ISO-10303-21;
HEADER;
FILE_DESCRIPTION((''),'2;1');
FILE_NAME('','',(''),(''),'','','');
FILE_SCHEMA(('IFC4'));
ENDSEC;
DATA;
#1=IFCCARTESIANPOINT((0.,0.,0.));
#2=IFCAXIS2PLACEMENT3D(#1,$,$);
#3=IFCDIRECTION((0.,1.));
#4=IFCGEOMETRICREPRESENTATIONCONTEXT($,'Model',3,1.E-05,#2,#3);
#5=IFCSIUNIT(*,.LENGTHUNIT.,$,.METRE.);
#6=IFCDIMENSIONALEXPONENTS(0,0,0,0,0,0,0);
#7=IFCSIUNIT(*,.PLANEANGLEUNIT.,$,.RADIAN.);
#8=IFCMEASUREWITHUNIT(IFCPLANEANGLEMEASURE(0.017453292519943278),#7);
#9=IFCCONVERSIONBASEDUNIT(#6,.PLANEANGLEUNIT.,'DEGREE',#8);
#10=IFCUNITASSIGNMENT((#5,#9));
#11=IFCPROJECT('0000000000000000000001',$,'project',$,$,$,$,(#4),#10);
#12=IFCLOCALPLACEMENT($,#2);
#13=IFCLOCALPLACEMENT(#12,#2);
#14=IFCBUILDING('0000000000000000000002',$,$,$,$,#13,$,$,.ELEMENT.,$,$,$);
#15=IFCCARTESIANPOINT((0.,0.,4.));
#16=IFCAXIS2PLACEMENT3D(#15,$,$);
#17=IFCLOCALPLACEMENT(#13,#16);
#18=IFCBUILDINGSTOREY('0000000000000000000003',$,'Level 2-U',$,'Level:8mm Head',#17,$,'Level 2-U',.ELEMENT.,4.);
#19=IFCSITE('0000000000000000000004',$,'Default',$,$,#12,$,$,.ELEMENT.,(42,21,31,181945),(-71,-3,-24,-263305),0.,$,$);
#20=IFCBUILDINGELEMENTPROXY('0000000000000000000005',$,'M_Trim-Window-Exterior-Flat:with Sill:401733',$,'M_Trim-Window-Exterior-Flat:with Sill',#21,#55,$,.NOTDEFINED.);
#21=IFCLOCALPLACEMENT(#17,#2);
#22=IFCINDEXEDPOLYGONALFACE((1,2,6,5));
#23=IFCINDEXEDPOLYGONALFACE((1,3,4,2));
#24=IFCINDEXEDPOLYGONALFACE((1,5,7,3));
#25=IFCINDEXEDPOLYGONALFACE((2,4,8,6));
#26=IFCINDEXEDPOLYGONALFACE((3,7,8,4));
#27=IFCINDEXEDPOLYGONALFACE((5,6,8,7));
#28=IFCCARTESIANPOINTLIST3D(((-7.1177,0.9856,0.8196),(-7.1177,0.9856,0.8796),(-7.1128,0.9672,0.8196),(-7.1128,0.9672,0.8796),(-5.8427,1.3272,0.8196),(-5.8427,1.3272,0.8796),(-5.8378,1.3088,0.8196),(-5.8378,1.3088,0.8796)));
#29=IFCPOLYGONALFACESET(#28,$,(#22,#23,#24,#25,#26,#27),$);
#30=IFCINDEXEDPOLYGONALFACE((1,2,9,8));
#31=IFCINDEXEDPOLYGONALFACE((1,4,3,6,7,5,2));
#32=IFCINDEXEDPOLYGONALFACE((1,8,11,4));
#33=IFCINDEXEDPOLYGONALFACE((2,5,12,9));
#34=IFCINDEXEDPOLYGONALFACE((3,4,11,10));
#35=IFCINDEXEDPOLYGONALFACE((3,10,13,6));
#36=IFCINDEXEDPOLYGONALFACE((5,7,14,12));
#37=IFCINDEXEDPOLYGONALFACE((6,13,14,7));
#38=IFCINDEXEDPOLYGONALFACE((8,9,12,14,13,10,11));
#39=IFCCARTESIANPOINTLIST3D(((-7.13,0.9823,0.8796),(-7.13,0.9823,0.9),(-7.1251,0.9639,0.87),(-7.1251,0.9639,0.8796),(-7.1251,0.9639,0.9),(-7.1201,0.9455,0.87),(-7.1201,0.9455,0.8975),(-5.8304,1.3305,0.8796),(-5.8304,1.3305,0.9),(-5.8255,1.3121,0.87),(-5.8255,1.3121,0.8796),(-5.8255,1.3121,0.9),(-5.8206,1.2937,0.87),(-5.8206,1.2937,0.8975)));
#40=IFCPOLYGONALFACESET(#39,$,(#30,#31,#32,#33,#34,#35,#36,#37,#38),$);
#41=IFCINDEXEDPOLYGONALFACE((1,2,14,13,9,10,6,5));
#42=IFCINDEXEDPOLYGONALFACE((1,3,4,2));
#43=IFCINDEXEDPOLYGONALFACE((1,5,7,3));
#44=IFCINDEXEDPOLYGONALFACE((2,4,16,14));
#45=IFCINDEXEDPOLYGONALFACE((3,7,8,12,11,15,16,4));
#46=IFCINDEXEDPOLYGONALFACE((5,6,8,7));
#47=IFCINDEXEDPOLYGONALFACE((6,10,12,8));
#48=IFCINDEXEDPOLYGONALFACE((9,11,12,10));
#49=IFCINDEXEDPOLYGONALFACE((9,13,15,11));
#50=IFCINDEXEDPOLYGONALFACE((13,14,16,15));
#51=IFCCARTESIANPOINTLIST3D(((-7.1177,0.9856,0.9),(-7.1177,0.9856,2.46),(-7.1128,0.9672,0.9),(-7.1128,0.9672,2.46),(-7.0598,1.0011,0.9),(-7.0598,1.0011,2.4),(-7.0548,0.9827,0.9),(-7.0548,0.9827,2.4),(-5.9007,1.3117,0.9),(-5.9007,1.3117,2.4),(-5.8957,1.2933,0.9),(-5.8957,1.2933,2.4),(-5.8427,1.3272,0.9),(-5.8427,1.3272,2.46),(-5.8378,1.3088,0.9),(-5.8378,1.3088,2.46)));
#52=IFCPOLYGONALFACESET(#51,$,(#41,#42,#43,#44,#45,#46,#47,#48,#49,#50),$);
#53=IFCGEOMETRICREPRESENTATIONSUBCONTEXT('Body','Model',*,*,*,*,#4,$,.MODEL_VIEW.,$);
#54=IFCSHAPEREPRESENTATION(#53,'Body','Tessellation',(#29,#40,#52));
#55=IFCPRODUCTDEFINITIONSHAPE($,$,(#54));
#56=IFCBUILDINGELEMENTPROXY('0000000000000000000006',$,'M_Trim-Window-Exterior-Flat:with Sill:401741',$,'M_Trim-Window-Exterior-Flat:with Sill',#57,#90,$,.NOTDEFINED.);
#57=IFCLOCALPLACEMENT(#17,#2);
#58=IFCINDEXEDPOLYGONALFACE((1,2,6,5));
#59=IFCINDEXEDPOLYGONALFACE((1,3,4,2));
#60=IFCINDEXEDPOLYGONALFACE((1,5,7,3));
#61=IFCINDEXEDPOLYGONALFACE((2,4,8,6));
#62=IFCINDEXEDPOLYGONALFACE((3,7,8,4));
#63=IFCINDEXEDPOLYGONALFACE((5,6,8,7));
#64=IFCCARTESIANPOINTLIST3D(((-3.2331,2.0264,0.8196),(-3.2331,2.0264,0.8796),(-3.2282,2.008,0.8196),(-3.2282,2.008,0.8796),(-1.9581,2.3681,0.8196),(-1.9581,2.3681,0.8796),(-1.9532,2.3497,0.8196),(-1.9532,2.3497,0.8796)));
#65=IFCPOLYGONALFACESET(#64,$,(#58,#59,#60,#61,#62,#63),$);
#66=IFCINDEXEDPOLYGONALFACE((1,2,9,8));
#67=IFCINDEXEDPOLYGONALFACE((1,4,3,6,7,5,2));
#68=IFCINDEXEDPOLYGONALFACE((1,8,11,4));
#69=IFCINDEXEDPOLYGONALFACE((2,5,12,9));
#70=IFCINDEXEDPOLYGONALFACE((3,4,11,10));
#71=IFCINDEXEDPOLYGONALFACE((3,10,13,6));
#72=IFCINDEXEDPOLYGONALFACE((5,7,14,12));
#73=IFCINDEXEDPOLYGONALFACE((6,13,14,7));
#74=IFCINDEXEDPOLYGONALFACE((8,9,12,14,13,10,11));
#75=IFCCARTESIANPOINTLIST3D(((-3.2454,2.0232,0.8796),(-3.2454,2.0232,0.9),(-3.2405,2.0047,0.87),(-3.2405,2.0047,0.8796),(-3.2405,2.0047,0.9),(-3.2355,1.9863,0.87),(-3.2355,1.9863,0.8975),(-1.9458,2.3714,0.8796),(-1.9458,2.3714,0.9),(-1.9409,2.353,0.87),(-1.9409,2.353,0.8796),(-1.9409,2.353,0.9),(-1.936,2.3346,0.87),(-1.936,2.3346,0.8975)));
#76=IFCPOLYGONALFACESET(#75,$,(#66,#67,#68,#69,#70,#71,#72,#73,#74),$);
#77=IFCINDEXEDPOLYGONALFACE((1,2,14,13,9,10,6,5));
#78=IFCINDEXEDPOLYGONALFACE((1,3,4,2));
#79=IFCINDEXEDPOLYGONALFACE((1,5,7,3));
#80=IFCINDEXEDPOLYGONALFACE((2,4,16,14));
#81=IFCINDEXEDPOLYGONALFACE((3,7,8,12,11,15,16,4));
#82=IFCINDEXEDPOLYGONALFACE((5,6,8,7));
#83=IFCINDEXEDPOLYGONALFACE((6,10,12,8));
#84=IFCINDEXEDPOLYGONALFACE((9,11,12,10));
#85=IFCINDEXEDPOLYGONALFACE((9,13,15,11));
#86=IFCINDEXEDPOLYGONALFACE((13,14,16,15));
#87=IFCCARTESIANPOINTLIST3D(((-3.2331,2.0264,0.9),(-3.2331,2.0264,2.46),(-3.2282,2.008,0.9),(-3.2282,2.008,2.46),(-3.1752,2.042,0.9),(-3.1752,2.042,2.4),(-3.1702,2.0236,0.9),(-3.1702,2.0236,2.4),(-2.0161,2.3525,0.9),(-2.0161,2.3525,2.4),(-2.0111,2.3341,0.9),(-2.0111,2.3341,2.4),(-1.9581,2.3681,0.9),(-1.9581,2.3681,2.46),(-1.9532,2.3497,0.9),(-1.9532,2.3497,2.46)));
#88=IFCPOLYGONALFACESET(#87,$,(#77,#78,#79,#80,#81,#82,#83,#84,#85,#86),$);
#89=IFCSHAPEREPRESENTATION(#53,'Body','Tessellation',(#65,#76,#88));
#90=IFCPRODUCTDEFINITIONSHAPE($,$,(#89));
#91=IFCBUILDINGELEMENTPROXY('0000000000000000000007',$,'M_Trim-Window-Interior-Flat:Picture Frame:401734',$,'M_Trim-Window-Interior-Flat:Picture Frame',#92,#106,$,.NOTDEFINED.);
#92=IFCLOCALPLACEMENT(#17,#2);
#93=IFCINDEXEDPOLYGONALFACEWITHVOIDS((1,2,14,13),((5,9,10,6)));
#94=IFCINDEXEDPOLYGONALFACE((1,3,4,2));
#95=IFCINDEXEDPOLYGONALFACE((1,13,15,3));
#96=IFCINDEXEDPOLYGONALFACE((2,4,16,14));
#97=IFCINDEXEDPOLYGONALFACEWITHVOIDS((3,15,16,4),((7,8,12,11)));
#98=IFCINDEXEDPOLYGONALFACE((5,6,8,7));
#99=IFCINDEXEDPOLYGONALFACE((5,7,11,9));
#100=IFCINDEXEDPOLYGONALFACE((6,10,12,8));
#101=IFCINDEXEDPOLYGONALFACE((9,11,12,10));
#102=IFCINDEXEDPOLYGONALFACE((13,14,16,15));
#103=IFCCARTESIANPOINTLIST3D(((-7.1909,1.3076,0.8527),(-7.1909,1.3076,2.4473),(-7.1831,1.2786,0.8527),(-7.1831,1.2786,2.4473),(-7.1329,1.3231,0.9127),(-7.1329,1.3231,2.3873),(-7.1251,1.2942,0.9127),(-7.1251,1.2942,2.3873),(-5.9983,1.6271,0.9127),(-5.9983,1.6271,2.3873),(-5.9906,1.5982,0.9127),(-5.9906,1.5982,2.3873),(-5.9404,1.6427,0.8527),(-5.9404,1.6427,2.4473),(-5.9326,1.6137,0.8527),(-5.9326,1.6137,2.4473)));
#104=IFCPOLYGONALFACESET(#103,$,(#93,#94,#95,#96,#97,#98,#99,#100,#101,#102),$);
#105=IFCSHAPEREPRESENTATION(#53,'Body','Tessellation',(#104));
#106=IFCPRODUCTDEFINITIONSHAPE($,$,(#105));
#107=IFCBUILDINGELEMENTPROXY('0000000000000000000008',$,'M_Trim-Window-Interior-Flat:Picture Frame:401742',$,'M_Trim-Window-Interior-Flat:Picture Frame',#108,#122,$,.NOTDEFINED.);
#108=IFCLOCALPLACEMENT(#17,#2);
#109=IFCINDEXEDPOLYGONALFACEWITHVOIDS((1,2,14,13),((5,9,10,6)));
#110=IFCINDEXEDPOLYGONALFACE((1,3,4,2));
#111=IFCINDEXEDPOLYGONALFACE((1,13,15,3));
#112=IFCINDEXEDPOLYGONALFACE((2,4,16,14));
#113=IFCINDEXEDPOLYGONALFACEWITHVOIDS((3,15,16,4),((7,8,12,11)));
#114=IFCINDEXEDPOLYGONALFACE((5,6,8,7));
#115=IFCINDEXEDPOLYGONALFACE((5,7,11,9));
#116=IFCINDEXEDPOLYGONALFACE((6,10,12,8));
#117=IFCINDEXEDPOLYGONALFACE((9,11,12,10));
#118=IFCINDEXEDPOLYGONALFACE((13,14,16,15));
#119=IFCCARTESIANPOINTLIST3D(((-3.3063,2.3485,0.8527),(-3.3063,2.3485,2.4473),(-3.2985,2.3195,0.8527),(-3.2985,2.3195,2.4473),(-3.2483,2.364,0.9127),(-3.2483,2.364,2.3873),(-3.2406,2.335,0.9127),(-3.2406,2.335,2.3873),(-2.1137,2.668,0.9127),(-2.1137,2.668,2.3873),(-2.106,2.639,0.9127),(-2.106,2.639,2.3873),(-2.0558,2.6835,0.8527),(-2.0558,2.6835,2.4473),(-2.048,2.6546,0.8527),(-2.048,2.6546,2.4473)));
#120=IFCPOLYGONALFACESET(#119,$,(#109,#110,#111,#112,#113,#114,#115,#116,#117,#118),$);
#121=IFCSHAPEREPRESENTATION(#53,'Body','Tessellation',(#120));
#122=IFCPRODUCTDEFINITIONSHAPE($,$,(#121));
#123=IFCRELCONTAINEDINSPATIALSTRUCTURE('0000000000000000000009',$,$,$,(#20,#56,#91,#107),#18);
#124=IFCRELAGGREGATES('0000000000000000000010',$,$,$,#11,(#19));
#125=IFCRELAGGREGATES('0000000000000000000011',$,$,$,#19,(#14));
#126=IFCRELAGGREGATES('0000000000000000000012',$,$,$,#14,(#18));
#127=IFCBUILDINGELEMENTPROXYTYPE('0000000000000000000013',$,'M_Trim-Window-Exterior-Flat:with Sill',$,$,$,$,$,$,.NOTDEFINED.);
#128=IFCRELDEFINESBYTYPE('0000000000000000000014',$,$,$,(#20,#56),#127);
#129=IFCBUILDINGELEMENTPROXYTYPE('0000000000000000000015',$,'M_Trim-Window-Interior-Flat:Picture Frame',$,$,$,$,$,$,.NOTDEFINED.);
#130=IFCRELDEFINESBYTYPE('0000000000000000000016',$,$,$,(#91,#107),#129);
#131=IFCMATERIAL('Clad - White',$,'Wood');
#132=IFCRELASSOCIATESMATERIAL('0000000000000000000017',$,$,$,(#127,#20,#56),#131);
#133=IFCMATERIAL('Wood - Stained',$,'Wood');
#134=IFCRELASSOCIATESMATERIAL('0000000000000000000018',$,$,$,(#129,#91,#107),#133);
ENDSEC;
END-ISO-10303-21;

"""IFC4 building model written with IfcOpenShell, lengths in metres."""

from ifc_helpers import new_model, entity, si_unit, converted_unit, direction, frame, origin, place, context, subcontext, project, spatial, indexed_curve, outline, extrude, source, transform, mapped, material, type_object, type_shapes, element, save


model = new_model("IFC4")

# Units and contexts
model_context = context("Model", 3, precision=1e-05, world=origin(), true_north=direction((0.0, 1.0)))
body_context = subcontext(model_context, "Body", "Model", "MODEL_VIEW")
ifc_project = project(units=[si_unit("LENGTHUNIT", "METRE"), converted_unit("PLANEANGLEUNIT", "DEGREE", entity("IfcPlaneAngleMeasure", 0.017453292519943278), si_unit("PLANEANGLEUNIT", "RADIAN"), dimensions=[0, 0, 0, 0, 0, 0, 0])], contexts=[model_context])

# Site, building, storey
site_placement = place(None, origin())
site = spatial("IfcSite", under=ifc_project, at=site_placement, Name="Default", CompositionType="ELEMENT", RefLatitude=(42, 21, 31, 181945), RefLongitude=(-71, -3, -24, -263305), RefElevation=0.0)
building_placement = place(site_placement, origin())
building = spatial("IfcBuilding", under=site, at=building_placement, CompositionType="ELEMENT")
storey_placement = place(building_placement, frame((0.0, 0.0, 4.0)))
storey = spatial("IfcBuildingStorey", under=building, at=storey_placement, Name="Level 2-U", ObjectType="Level:8mm Head", LongName="Level 2-U", CompositionType="ELEMENT", Elevation=4.0)

# Building element proxies
ifc_material_1 = material(Name="Clad - White", Category="Wood")
ifc_material_2 = material(Name="Wood - Stained", Category="Wood")
building_element_proxy_type_1 = type_object("IfcBuildingElementProxyType", Name="M_Trim-Window-Exterior-Flat:with Sill", PredefinedType="NOTDEFINED", material=ifc_material_1)
shared_shape_1 = source(origin(), body_context, "Body", "SweptSolid", [
    extrude(outline(indexed_curve([(-0.66, -0.03), (0.66, -0.03), (0.66, 0.03), (-0.66, 0.03), (-0.66, -0.03)], self_intersect=False)), frame((0.0, -1.5504, 0.0), z_axis=(0.0, 0.0, 1.0), x_axis=(-1.0, 0.0, 0.0)), (0.0, 0.0, 1.0), 0.019),
    extrude(outline(indexed_curve([(-0.019, -0.0152), (0.0, -0.0152), (0.0, -0.0057), (0.019, -0.0057), (0.019, 0.0148), (0.0, 0.0148), (-0.019, 0.0123), (-0.019, -0.0152)], self_intersect=False)), frame((-0.6727, -1.5148, 0.019), z_axis=(1.0, 0.0, 0.0), x_axis=(0.0, 0.0, -1.0)), (0.0, 0.0, 1.0), 1.3454),
    extrude(outline(indexed_curve([(-0.795, -0.66), (0.765, -0.66), (0.765, -0.6), (-0.735, -0.6), (-0.735, 0.6), (0.765, 0.6), (0.765, 0.66), (-0.795, 0.66), (-0.795, -0.66)], self_intersect=False)), frame((0.0, -0.735, 0.0), z_axis=(0.0, 0.0, 1.0), x_axis=(0.0, -1.0, 0.0)), (0.0, 0.0, 1.0), 0.019),
])
type_shapes(building_element_proxy_type_1, [shared_shape_1])
for number, where, z_axis, x_axis, name in (
    (1, (-6.4802, 1.1564, 2.4), (0.258819, -0.965926, 0.0), (0.965926, 0.258819, 0.0), "M_Trim-Window-Exterior-Flat:with Sill:401733"),
    (2, (-2.5956, 2.1973, 2.4), (0.258819, -0.965926, 0.0), (0.965926, 0.258819, 0.0), "M_Trim-Window-Exterior-Flat:with Sill:401741"),
):
    element("IfcBuildingElementProxy", number, at=place(storey_placement, frame(where, z_axis=z_axis, x_axis=x_axis)), inside=storey, type_object=building_element_proxy_type_1, material=ifc_material_1, Name=name, ObjectType="M_Trim-Window-Exterior-Flat:with Sill", PredefinedType="NOTDEFINED", context=body_context, shape_type="MappedRepresentation", body=[
        mapped(shared_shape_1, transform((0.0, 0.0, 0.0), scale=1.0)),
    ])
building_element_proxy_type_2 = type_object("IfcBuildingElementProxyType", Name="M_Trim-Window-Interior-Flat:Picture Frame", PredefinedType="NOTDEFINED", material=ifc_material_2)
shared_shape_2 = source(origin(), body_context, "Body", "SweptSolid", [
    extrude(outline(indexed_curve([(-0.6473, -0.7973), (0.6473, -0.7973), (0.6473, 0.7973), (-0.6473, 0.7973), (-0.6473, -0.7973)], self_intersect=False), holes=[indexed_curve([(-0.5873, -0.7373), (-0.5873, 0.7373), (0.5873, 0.7373), (0.5873, -0.7373), (-0.5873, -0.7373)], self_intersect=False)]), frame((0.0, -0.75, 0.0), z_axis=(0.0, 0.0, 1.0), x_axis=(-1.0, 0.0, 0.0)), (0.0, 0.0, 1.0), 0.03),
])
type_shapes(building_element_proxy_type_2, [shared_shape_2])
for number, where, z_axis, x_axis, name in (
    (3, (-6.5579, 1.4462, 2.4), (-0.258819, 0.965926, 0.0), (-0.965926, -0.258819, 0.0), "M_Trim-Window-Interior-Flat:Picture Frame:401734"),
    (4, (-2.6733, 2.487, 2.4), (-0.258819, 0.965926, 0.0), (-0.965926, -0.258819, 0.0), "M_Trim-Window-Interior-Flat:Picture Frame:401742"),
):
    element("IfcBuildingElementProxy", number, at=place(storey_placement, frame(where, z_axis=z_axis, x_axis=x_axis)), inside=storey, type_object=building_element_proxy_type_2, material=ifc_material_2, Name=name, ObjectType="M_Trim-Window-Interior-Flat:Picture Frame", PredefinedType="NOTDEFINED", context=body_context, shape_type="MappedRepresentation", body=[
        mapped(shared_shape_2, transform((0.0, 0.0, 0.0), scale=1.0)),
    ])

save(model, "model.ifc")
